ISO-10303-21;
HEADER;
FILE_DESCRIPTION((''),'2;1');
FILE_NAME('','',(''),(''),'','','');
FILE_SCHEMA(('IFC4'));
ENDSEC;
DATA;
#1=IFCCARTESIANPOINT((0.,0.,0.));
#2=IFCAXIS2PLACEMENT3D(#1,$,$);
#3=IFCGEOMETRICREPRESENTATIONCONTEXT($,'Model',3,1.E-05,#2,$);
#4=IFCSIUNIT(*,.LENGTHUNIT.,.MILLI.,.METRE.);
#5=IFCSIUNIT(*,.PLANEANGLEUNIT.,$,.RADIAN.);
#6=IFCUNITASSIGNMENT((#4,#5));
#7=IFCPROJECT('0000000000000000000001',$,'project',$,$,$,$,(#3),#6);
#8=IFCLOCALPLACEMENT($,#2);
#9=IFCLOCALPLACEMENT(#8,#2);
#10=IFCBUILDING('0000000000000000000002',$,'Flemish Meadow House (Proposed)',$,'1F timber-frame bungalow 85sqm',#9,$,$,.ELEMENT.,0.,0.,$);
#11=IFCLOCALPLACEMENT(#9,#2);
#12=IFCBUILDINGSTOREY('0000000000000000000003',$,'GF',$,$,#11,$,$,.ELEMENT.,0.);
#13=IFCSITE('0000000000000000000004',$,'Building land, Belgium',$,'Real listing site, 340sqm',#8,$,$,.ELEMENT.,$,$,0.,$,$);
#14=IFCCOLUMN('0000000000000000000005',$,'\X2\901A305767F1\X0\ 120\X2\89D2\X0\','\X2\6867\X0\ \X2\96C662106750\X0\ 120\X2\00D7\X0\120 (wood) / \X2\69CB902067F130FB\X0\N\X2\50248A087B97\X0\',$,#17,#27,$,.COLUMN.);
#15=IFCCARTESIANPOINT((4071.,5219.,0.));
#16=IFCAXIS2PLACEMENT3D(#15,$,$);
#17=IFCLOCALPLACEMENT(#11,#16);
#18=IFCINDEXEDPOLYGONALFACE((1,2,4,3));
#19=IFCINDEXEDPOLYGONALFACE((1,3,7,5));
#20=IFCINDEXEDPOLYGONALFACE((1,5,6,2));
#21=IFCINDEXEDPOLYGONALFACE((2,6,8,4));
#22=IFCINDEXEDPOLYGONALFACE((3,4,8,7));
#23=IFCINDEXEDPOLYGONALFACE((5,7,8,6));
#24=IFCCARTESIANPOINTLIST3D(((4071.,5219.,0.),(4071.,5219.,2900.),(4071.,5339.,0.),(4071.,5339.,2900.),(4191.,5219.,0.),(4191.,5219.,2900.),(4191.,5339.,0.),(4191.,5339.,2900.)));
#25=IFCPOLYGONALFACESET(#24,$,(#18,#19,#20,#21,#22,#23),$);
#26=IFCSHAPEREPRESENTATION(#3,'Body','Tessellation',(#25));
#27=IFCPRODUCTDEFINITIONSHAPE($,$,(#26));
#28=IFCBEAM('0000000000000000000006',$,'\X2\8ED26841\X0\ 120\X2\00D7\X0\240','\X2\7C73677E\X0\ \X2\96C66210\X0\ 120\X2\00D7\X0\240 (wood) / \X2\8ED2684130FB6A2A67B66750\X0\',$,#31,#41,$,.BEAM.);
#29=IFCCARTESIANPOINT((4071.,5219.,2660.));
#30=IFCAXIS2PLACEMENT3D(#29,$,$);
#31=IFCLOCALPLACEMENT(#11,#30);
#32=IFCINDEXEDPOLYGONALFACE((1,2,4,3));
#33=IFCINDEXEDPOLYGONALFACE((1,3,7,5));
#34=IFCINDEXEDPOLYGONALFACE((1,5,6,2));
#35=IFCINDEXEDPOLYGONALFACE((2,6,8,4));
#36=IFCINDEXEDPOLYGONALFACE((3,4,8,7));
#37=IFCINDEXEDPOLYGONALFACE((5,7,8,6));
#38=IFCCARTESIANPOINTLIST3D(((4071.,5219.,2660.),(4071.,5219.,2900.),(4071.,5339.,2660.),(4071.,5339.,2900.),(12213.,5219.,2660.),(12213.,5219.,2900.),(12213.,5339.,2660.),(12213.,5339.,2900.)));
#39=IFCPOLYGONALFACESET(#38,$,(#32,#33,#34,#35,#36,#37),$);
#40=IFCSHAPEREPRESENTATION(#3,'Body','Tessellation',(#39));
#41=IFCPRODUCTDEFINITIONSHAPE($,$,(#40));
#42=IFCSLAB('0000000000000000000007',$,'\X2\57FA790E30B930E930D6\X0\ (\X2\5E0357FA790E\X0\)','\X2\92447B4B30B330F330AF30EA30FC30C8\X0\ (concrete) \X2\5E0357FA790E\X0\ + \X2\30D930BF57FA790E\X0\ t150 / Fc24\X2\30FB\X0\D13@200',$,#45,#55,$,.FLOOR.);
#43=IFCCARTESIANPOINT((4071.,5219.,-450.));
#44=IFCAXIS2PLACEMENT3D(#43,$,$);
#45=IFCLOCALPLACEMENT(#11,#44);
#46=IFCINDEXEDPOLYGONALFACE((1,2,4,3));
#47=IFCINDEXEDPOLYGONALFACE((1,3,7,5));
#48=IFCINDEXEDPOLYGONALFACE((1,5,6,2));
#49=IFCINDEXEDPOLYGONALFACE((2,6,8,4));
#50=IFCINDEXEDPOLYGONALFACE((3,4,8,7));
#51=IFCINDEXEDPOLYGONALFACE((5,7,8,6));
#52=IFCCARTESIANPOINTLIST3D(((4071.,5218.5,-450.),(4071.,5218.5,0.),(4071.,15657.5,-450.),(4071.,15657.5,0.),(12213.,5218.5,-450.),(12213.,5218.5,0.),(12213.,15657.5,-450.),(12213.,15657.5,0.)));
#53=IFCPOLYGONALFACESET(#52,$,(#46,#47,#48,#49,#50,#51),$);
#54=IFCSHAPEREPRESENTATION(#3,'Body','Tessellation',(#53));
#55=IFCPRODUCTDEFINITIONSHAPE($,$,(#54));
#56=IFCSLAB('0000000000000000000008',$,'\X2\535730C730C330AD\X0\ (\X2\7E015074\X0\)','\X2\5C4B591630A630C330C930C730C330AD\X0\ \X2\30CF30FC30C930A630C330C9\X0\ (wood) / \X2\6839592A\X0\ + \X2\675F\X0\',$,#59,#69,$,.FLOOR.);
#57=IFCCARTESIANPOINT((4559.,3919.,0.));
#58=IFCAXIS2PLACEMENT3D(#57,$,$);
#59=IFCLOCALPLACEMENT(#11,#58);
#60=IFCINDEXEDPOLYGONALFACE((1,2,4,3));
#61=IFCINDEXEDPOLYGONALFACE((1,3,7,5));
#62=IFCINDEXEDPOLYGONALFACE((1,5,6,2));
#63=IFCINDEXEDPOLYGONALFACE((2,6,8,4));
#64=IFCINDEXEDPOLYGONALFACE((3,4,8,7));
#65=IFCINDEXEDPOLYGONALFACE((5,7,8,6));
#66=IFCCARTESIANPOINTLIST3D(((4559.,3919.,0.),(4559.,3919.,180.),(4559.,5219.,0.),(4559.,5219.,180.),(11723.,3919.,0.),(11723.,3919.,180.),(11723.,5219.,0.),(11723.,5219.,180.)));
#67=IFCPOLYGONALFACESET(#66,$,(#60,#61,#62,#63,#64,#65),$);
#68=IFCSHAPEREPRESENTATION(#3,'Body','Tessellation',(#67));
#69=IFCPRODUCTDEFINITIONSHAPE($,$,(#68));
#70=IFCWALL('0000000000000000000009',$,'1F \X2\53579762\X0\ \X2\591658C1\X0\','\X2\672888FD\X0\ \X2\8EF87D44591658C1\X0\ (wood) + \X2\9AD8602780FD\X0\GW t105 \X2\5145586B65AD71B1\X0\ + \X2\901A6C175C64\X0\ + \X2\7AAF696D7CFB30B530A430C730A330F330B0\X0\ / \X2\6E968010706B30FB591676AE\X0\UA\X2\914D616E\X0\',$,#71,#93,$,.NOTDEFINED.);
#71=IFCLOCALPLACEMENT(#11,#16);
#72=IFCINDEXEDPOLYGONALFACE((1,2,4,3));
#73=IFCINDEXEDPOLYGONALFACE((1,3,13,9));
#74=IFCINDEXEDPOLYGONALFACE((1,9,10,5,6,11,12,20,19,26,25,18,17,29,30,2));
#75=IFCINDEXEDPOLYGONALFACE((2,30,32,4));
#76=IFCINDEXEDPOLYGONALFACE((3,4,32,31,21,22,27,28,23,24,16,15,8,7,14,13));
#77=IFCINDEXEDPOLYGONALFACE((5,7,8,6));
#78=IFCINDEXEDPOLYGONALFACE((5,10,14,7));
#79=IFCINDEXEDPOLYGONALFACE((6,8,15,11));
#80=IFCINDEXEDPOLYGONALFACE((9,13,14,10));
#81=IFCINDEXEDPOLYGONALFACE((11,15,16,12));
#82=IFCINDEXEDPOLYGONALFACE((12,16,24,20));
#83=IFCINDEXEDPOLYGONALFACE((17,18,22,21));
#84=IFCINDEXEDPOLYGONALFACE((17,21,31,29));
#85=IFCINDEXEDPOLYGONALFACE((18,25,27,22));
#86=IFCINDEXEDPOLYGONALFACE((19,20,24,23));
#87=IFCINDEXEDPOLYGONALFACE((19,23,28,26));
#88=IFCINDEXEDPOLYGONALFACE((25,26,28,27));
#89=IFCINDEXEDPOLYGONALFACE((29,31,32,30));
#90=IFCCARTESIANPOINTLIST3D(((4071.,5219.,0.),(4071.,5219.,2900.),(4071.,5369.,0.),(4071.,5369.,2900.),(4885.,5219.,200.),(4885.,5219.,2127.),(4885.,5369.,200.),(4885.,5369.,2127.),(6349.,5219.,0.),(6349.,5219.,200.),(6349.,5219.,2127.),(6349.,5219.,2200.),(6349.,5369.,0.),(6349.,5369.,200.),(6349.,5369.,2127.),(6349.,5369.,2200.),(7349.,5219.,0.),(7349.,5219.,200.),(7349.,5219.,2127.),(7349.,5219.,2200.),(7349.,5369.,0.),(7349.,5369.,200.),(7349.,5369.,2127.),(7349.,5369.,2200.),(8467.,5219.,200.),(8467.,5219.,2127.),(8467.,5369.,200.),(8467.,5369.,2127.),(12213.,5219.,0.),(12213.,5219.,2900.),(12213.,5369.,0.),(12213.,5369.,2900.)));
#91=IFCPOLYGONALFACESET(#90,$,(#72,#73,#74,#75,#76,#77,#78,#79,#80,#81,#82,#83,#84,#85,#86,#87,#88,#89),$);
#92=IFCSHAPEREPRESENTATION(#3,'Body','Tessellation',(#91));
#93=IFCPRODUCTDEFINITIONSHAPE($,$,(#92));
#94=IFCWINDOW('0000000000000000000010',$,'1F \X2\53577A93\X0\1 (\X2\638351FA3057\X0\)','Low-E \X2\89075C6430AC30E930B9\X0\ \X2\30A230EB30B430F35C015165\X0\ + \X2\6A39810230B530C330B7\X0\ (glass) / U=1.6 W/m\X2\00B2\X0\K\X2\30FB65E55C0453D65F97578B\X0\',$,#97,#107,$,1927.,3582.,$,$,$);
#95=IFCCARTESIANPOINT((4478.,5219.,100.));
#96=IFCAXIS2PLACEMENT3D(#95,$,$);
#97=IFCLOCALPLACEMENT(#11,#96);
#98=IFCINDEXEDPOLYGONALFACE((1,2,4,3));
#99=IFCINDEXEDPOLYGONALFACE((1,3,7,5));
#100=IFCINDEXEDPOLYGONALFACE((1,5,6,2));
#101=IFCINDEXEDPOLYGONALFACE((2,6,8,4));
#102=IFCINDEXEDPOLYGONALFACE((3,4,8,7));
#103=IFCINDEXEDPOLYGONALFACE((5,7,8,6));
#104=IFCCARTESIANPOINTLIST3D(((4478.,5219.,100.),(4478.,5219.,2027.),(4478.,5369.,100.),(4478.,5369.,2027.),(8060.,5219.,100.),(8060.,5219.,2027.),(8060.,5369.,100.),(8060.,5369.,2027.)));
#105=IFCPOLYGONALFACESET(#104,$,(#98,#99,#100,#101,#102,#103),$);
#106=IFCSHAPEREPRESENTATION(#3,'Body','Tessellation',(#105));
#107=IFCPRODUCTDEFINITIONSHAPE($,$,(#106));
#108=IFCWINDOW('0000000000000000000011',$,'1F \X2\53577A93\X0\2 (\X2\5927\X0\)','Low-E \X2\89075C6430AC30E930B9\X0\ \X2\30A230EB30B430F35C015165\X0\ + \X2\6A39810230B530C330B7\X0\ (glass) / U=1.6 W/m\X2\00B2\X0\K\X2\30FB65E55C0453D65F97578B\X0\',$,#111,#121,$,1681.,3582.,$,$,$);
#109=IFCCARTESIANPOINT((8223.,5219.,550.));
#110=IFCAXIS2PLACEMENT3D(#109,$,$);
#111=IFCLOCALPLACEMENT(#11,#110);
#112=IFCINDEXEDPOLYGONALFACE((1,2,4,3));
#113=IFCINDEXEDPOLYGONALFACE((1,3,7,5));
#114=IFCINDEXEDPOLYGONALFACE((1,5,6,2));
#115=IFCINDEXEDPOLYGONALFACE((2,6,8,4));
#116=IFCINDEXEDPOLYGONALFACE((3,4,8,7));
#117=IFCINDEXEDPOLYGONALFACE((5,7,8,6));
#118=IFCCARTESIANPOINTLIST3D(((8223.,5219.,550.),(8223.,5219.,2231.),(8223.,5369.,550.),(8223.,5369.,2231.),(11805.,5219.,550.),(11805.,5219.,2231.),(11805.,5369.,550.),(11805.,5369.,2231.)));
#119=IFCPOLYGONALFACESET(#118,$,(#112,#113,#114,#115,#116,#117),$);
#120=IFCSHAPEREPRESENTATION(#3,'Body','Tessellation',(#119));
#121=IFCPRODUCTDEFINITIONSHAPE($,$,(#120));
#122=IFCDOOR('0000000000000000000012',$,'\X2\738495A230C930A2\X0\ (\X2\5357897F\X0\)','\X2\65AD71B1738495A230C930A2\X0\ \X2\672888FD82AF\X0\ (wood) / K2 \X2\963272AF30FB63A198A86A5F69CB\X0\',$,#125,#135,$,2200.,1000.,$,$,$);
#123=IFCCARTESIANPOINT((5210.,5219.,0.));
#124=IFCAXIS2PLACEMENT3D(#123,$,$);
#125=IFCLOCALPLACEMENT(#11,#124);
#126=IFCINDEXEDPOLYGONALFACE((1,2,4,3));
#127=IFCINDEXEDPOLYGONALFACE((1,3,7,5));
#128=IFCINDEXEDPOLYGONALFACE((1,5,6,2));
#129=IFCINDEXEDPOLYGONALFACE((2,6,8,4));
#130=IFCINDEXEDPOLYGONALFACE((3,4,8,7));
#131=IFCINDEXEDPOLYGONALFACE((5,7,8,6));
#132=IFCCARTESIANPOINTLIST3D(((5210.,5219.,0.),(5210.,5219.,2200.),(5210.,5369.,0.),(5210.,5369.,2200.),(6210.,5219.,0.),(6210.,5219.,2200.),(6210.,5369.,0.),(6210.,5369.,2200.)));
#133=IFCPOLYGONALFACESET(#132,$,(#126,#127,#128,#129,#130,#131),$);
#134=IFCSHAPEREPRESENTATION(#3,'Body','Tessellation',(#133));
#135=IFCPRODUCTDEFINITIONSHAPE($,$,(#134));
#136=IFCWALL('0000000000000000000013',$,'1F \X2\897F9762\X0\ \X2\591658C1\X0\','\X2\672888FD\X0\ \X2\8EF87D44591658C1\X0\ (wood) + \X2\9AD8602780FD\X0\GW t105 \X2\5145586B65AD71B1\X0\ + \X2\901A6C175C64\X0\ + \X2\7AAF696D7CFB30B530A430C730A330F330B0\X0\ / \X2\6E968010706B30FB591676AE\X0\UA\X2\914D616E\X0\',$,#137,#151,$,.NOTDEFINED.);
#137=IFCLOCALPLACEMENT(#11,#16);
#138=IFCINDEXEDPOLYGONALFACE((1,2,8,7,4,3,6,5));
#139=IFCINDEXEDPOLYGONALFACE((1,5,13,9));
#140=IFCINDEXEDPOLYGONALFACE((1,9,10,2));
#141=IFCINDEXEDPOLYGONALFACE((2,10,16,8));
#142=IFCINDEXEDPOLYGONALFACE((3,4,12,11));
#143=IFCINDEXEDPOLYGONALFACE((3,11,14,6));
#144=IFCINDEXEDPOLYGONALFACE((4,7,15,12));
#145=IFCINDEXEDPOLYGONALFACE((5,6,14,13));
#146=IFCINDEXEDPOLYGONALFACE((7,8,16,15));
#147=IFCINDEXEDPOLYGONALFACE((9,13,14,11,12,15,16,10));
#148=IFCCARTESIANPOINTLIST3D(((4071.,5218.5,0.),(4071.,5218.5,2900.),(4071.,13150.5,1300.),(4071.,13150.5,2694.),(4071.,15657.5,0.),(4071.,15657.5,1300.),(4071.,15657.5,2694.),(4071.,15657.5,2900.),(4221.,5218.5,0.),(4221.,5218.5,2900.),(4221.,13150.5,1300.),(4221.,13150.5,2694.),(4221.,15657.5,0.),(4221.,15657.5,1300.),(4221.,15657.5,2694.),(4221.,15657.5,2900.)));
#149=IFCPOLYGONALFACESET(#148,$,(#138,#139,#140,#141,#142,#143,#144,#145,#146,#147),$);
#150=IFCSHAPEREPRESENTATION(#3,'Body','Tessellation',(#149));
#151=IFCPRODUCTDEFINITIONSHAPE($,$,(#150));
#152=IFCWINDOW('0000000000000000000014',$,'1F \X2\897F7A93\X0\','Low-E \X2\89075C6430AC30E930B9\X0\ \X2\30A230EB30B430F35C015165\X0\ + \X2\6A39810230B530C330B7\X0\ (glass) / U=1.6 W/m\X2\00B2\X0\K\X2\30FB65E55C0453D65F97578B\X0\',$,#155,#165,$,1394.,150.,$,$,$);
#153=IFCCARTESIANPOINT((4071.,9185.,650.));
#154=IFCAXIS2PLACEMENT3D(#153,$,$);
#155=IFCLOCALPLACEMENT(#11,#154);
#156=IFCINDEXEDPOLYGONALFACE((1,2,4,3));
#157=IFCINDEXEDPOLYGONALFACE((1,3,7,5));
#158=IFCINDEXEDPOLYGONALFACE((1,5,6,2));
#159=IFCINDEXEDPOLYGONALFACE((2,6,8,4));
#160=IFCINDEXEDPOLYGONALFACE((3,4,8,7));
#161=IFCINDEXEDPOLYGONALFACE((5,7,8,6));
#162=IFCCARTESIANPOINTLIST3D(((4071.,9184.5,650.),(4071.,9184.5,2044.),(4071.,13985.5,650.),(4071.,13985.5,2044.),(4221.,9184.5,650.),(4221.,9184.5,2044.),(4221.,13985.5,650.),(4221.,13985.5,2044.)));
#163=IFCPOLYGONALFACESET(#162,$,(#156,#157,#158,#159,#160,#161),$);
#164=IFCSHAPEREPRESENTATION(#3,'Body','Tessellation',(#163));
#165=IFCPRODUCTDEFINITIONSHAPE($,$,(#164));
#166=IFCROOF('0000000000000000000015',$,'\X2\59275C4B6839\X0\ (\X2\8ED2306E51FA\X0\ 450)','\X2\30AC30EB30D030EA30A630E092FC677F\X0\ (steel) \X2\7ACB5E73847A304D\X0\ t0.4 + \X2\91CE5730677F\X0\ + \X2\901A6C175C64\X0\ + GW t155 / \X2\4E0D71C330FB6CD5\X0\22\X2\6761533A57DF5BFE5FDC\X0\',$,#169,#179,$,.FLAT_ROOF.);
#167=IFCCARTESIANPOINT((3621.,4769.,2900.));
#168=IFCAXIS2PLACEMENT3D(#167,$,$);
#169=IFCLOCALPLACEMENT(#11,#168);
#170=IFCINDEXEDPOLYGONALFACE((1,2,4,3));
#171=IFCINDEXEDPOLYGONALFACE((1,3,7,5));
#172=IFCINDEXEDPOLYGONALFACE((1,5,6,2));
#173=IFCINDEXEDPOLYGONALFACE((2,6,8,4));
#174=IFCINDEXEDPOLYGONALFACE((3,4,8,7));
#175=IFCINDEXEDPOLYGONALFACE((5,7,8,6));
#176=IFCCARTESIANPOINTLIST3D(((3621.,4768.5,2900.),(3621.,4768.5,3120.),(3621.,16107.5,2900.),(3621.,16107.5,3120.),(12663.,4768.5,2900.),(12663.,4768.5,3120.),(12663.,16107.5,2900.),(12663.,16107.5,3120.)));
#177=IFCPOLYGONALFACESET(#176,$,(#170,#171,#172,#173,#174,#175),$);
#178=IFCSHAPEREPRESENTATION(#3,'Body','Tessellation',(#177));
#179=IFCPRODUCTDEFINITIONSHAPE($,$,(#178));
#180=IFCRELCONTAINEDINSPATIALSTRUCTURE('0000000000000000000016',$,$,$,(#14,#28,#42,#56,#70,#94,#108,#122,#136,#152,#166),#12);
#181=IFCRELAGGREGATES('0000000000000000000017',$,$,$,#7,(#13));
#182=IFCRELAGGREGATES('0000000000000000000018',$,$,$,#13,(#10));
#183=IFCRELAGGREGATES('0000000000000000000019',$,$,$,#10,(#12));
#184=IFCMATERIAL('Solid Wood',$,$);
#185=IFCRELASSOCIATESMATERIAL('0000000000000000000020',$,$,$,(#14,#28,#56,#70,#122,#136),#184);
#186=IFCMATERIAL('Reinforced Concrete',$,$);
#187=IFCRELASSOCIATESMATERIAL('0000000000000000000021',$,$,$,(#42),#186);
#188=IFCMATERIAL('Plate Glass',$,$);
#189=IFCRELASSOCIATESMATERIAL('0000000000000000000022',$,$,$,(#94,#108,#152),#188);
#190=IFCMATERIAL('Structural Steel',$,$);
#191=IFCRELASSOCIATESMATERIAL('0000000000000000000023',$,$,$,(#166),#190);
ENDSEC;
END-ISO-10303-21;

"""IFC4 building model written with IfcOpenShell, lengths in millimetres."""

from ifc_helpers import new_model, si_unit, frame, frame_2d, origin, place, context, project, spatial, rectangle, extrude, material, element, fill, save


model = new_model("IFC4")

# Units and contexts
model_context = context("Model", 3, precision=1e-05, world=origin())
ifc_project = project(units=[si_unit("LENGTHUNIT", "METRE", prefix="MILLI"), si_unit("PLANEANGLEUNIT", "RADIAN")], contexts=[model_context])

# Site, building, storey
site_placement = place(None, origin())
site = spatial("IfcSite", under=ifc_project, at=site_placement, Name="Building land, Belgium", ObjectType="Real listing site, 340sqm", CompositionType="ELEMENT", RefElevation=0.0)
building_placement = place(site_placement, origin())
building = spatial("IfcBuilding", under=site, at=building_placement, Name="Flemish Meadow House (Proposed)", ObjectType="1F timber-frame bungalow 85sqm", CompositionType="ELEMENT", ElevationOfRefHeight=0.0, ElevationOfTerrain=0.0)
storey_placement = place(building_placement, origin())
storey = spatial("IfcBuildingStorey", under=building, at=storey_placement, Name="GF", CompositionType="ELEMENT", Elevation=0.0)

# Column
ifc_material_1 = material(Name="Solid Wood")
column_1_placement = place(storey_placement, frame((4071.0, 5219.0, 0.0)))
element("IfcColumn", 1, at=column_1_placement, inside=storey, material=ifc_material_1, Name="通し柱 120角", Description="桧 集成材 120×120 (wood) / 構造柱・N値計算", PredefinedType="COLUMN", context=model_context, shape_type="SweptSolid", body=[
    extrude(rectangle(XDim=120.0, YDim=120.0, at=frame_2d((60.0, 60.0))), frame((4071.0, 5219.0, 0.0)), (0.0, 0.0, 1.0), 2900.0),
])

# Beam
beam_1_placement = place(storey_placement, frame((4071.0, 5219.0, 2660.0)))
element("IfcBeam", 2, at=beam_1_placement, inside=storey, material=ifc_material_1, Name="軒桁 120×240", Description="米松 集成 120×240 (wood) / 軒桁・横架材", PredefinedType="BEAM", context=model_context, shape_type="SweptSolid", body=[
    extrude(rectangle(XDim=8142.0, YDim=120.0, at=frame_2d((4071.0, 60.0))), frame((4071.0, 5219.0, 2660.0)), (0.0, 0.0, 1.0), 240.0),
])

# Slabs
ifc_material_2 = material(Name="Reinforced Concrete")
slab_1_placement = place(storey_placement, frame((4071.0, 5219.0, -450.0)))
element("IfcSlab", 3, at=slab_1_placement, inside=storey, material=ifc_material_2, Name="基礎スラブ (布基礎)", Description="鉄筋コンクリート (concrete) 布基礎 + ベタ基礎 t150 / Fc24・D13@200", PredefinedType="FLOOR", context=model_context, shape_type="SweptSolid", body=[
    extrude(rectangle(XDim=8142.0, YDim=10439.0, at=frame_2d((4071.0, 5219.0))), frame((4071.0, 5219.0, -450.0)), (0.0, 0.0, 1.0), 450.0),
])
slab_2_placement = place(storey_placement, frame((4559.0, 3919.0, 0.0)))
element("IfcSlab", 4, at=slab_2_placement, inside=storey, material=ifc_material_1, Name="南デッキ (縁側)", Description="屋外ウッドデッキ ハードウッド (wood) / 根太 + 束", PredefinedType="FLOOR", context=model_context, shape_type="SweptSolid", body=[
    extrude(rectangle(XDim=7164.0, YDim=1300.0, at=frame_2d((3582.0, 650.0))), frame((4559.0, 3919.0, 0.0)), (0.0, 0.0, 1.0), 180.0),
])

# Wall, openings, windows, door
wall_1_placement = place(storey_placement, frame((4071.0, 5219.0, 0.0)))
wall_1 = element("IfcWall", 5, at=wall_1_placement, inside=storey, material=ifc_material_1, Name="1F 南面 外壁", Description="木製 軸組外壁 (wood) + 高性能GW t105 充填断熱 + 通気層 + 窯業系サイディング / 準耐火・外皮UA配慮", PredefinedType="NOTDEFINED", context=model_context, shape_type="SweptSolid", body=[
    extrude(rectangle(XDim=8142.0, YDim=150.0, at=frame_2d((4071.0, 75.0))), frame((4071.0, 5219.0, 0.0)), (0.0, 0.0, 1.0), 2900.0),
])
opening_1_placement = place(storey_placement, frame((4478.0, 5219.0, 100.0)))
opening_1 = element("IfcOpeningElement", 6, at=opening_1_placement, cuts=wall_1, PredefinedType="NOTDEFINED", context=model_context, shape_type="SweptSolid", body=[
    extrude(rectangle(XDim=3582.0, YDim=150.0, at=frame_2d((1791.0, 75.0))), frame((4478.0, 5219.0, 100.0)), (0.0, 0.0, 1.0), 1927.0),
])
opening_2_placement = place(storey_placement, frame((8223.0, 5219.0, 550.0)))
opening_2 = element("IfcOpeningElement", 7, at=opening_2_placement, cuts=wall_1, PredefinedType="NOTDEFINED", context=model_context, shape_type="SweptSolid", body=[
    extrude(rectangle(XDim=3582.0, YDim=150.0, at=frame_2d((1791.0, 75.0))), frame((8223.0, 5219.0, 550.0)), (0.0, 0.0, 1.0), 1681.0),
])
opening_3_placement = place(storey_placement, frame((5210.0, 5219.0, 0.0)))
opening_3 = element("IfcOpeningElement", 8, at=opening_3_placement, cuts=wall_1, PredefinedType="NOTDEFINED", context=model_context, shape_type="SweptSolid", body=[
    extrude(rectangle(XDim=1000.0, YDim=150.0, at=frame_2d((500.0, 75.0))), frame((5210.0, 5219.0, 0.0)), (0.0, 0.0, 1.0), 2200.0),
])
ifc_material_3 = material(Name="Plate Glass")
window_1_placement = place(storey_placement, frame((4478.0, 5219.0, 100.0)))
window_1 = element("IfcWindow", 9, at=window_1_placement, inside=storey, material=ifc_material_3, Name="1F 南窓1 (掃出し)", Description="Low-E 複層ガラス アルゴン封入 + 樹脂サッシ (glass) / U=1.6 W/m²K・日射取得型", OverallHeight=1927.0, OverallWidth=3582.0, context=model_context, shape_type="SweptSolid", body=[
    extrude(rectangle(XDim=3582.0, YDim=150.0, at=frame_2d((1791.0, 75.0))), frame((4478.0, 5219.0, 100.0)), (0.0, 0.0, 1.0), 1927.0),
])
fill(opening_1, window_1)
window_2_placement = place(storey_placement, frame((8223.0, 5219.0, 550.0)))
window_2 = element("IfcWindow", 10, at=window_2_placement, inside=storey, material=ifc_material_3, Name="1F 南窓2 (大)", Description="Low-E 複層ガラス アルゴン封入 + 樹脂サッシ (glass) / U=1.6 W/m²K・日射取得型", OverallHeight=1681.0, OverallWidth=3582.0, context=model_context, shape_type="SweptSolid", body=[
    extrude(rectangle(XDim=3582.0, YDim=150.0, at=frame_2d((1791.0, 75.0))), frame((8223.0, 5219.0, 550.0)), (0.0, 0.0, 1.0), 1681.0),
])
fill(opening_2, window_2)
door_placement = place(storey_placement, frame((5210.0, 5219.0, 0.0)))
door = element("IfcDoor", 11, at=door_placement, inside=storey, material=ifc_material_1, Name="玄関ドア (南西)", Description="断熱玄関ドア 木製芯 (wood) / K2 防犯・採風機構", OverallHeight=2200.0, OverallWidth=1000.0, context=model_context, shape_type="SweptSolid", body=[
    extrude(rectangle(XDim=1000.0, YDim=150.0, at=frame_2d((500.0, 75.0))), frame((5210.0, 5219.0, 0.0)), (0.0, 0.0, 1.0), 2200.0),
])
fill(opening_3, door)

# Wall, opening, window
wall_2_placement = place(storey_placement, frame((4071.0, 5219.0, 0.0)))
wall_2 = element("IfcWall", 12, at=wall_2_placement, inside=storey, material=ifc_material_1, Name="1F 西面 外壁", Description="木製 軸組外壁 (wood) + 高性能GW t105 充填断熱 + 通気層 + 窯業系サイディング / 準耐火・外皮UA配慮", PredefinedType="NOTDEFINED", context=model_context, shape_type="SweptSolid", body=[
    extrude(rectangle(XDim=150.0, YDim=10439.0, at=frame_2d((75.0, 5219.0))), frame((4071.0, 5219.0, 0.0)), (0.0, 0.0, 1.0), 2900.0),
])
opening_4_placement = place(storey_placement, frame((4071.0, 9185.0, 650.0)))
opening_4 = element("IfcOpeningElement", 13, at=opening_4_placement, cuts=wall_2, PredefinedType="NOTDEFINED", context=model_context, shape_type="SweptSolid", body=[
    extrude(rectangle(XDim=150.0, YDim=4801.0, at=frame_2d((75.0, 2400.0))), frame((4071.0, 9185.0, 650.0)), (0.0, 0.0, 1.0), 1394.0),
])
window_3_placement = place(storey_placement, frame((4071.0, 9185.0, 650.0)))
window_3 = element("IfcWindow", 14, at=window_3_placement, inside=storey, material=ifc_material_3, Name="1F 西窓", Description="Low-E 複層ガラス アルゴン封入 + 樹脂サッシ (glass) / U=1.6 W/m²K・日射取得型", OverallHeight=1394.0, OverallWidth=150.0, context=model_context, shape_type="SweptSolid", body=[
    extrude(rectangle(XDim=150.0, YDim=4801.0, at=frame_2d((75.0, 2400.0))), frame((4071.0, 9185.0, 650.0)), (0.0, 0.0, 1.0), 1394.0),
])
fill(opening_4, window_3)

# Roof
ifc_material_4 = material(Name="Structural Steel")
roof_placement = place(storey_placement, frame((3621.0, 4769.0, 2900.0)))
element("IfcRoof", 15, at=roof_placement, inside=storey, material=ifc_material_4, Name="大屋根 (軒の出 450)", Description="ガルバリウム鋼板 (steel) 立平葺き t0.4 + 野地板 + 通気層 + GW t155 / 不燃・法22条区域対応", PredefinedType="FLAT_ROOF", context=model_context, shape_type="SweptSolid", body=[
    extrude(rectangle(XDim=9042.0, YDim=11339.0, at=frame_2d((4521.0, 5669.0))), frame((3621.0, 4769.0, 2900.0)), (0.0, 0.0, 1.0), 220.0),
])

save(model, "model.ifc")
